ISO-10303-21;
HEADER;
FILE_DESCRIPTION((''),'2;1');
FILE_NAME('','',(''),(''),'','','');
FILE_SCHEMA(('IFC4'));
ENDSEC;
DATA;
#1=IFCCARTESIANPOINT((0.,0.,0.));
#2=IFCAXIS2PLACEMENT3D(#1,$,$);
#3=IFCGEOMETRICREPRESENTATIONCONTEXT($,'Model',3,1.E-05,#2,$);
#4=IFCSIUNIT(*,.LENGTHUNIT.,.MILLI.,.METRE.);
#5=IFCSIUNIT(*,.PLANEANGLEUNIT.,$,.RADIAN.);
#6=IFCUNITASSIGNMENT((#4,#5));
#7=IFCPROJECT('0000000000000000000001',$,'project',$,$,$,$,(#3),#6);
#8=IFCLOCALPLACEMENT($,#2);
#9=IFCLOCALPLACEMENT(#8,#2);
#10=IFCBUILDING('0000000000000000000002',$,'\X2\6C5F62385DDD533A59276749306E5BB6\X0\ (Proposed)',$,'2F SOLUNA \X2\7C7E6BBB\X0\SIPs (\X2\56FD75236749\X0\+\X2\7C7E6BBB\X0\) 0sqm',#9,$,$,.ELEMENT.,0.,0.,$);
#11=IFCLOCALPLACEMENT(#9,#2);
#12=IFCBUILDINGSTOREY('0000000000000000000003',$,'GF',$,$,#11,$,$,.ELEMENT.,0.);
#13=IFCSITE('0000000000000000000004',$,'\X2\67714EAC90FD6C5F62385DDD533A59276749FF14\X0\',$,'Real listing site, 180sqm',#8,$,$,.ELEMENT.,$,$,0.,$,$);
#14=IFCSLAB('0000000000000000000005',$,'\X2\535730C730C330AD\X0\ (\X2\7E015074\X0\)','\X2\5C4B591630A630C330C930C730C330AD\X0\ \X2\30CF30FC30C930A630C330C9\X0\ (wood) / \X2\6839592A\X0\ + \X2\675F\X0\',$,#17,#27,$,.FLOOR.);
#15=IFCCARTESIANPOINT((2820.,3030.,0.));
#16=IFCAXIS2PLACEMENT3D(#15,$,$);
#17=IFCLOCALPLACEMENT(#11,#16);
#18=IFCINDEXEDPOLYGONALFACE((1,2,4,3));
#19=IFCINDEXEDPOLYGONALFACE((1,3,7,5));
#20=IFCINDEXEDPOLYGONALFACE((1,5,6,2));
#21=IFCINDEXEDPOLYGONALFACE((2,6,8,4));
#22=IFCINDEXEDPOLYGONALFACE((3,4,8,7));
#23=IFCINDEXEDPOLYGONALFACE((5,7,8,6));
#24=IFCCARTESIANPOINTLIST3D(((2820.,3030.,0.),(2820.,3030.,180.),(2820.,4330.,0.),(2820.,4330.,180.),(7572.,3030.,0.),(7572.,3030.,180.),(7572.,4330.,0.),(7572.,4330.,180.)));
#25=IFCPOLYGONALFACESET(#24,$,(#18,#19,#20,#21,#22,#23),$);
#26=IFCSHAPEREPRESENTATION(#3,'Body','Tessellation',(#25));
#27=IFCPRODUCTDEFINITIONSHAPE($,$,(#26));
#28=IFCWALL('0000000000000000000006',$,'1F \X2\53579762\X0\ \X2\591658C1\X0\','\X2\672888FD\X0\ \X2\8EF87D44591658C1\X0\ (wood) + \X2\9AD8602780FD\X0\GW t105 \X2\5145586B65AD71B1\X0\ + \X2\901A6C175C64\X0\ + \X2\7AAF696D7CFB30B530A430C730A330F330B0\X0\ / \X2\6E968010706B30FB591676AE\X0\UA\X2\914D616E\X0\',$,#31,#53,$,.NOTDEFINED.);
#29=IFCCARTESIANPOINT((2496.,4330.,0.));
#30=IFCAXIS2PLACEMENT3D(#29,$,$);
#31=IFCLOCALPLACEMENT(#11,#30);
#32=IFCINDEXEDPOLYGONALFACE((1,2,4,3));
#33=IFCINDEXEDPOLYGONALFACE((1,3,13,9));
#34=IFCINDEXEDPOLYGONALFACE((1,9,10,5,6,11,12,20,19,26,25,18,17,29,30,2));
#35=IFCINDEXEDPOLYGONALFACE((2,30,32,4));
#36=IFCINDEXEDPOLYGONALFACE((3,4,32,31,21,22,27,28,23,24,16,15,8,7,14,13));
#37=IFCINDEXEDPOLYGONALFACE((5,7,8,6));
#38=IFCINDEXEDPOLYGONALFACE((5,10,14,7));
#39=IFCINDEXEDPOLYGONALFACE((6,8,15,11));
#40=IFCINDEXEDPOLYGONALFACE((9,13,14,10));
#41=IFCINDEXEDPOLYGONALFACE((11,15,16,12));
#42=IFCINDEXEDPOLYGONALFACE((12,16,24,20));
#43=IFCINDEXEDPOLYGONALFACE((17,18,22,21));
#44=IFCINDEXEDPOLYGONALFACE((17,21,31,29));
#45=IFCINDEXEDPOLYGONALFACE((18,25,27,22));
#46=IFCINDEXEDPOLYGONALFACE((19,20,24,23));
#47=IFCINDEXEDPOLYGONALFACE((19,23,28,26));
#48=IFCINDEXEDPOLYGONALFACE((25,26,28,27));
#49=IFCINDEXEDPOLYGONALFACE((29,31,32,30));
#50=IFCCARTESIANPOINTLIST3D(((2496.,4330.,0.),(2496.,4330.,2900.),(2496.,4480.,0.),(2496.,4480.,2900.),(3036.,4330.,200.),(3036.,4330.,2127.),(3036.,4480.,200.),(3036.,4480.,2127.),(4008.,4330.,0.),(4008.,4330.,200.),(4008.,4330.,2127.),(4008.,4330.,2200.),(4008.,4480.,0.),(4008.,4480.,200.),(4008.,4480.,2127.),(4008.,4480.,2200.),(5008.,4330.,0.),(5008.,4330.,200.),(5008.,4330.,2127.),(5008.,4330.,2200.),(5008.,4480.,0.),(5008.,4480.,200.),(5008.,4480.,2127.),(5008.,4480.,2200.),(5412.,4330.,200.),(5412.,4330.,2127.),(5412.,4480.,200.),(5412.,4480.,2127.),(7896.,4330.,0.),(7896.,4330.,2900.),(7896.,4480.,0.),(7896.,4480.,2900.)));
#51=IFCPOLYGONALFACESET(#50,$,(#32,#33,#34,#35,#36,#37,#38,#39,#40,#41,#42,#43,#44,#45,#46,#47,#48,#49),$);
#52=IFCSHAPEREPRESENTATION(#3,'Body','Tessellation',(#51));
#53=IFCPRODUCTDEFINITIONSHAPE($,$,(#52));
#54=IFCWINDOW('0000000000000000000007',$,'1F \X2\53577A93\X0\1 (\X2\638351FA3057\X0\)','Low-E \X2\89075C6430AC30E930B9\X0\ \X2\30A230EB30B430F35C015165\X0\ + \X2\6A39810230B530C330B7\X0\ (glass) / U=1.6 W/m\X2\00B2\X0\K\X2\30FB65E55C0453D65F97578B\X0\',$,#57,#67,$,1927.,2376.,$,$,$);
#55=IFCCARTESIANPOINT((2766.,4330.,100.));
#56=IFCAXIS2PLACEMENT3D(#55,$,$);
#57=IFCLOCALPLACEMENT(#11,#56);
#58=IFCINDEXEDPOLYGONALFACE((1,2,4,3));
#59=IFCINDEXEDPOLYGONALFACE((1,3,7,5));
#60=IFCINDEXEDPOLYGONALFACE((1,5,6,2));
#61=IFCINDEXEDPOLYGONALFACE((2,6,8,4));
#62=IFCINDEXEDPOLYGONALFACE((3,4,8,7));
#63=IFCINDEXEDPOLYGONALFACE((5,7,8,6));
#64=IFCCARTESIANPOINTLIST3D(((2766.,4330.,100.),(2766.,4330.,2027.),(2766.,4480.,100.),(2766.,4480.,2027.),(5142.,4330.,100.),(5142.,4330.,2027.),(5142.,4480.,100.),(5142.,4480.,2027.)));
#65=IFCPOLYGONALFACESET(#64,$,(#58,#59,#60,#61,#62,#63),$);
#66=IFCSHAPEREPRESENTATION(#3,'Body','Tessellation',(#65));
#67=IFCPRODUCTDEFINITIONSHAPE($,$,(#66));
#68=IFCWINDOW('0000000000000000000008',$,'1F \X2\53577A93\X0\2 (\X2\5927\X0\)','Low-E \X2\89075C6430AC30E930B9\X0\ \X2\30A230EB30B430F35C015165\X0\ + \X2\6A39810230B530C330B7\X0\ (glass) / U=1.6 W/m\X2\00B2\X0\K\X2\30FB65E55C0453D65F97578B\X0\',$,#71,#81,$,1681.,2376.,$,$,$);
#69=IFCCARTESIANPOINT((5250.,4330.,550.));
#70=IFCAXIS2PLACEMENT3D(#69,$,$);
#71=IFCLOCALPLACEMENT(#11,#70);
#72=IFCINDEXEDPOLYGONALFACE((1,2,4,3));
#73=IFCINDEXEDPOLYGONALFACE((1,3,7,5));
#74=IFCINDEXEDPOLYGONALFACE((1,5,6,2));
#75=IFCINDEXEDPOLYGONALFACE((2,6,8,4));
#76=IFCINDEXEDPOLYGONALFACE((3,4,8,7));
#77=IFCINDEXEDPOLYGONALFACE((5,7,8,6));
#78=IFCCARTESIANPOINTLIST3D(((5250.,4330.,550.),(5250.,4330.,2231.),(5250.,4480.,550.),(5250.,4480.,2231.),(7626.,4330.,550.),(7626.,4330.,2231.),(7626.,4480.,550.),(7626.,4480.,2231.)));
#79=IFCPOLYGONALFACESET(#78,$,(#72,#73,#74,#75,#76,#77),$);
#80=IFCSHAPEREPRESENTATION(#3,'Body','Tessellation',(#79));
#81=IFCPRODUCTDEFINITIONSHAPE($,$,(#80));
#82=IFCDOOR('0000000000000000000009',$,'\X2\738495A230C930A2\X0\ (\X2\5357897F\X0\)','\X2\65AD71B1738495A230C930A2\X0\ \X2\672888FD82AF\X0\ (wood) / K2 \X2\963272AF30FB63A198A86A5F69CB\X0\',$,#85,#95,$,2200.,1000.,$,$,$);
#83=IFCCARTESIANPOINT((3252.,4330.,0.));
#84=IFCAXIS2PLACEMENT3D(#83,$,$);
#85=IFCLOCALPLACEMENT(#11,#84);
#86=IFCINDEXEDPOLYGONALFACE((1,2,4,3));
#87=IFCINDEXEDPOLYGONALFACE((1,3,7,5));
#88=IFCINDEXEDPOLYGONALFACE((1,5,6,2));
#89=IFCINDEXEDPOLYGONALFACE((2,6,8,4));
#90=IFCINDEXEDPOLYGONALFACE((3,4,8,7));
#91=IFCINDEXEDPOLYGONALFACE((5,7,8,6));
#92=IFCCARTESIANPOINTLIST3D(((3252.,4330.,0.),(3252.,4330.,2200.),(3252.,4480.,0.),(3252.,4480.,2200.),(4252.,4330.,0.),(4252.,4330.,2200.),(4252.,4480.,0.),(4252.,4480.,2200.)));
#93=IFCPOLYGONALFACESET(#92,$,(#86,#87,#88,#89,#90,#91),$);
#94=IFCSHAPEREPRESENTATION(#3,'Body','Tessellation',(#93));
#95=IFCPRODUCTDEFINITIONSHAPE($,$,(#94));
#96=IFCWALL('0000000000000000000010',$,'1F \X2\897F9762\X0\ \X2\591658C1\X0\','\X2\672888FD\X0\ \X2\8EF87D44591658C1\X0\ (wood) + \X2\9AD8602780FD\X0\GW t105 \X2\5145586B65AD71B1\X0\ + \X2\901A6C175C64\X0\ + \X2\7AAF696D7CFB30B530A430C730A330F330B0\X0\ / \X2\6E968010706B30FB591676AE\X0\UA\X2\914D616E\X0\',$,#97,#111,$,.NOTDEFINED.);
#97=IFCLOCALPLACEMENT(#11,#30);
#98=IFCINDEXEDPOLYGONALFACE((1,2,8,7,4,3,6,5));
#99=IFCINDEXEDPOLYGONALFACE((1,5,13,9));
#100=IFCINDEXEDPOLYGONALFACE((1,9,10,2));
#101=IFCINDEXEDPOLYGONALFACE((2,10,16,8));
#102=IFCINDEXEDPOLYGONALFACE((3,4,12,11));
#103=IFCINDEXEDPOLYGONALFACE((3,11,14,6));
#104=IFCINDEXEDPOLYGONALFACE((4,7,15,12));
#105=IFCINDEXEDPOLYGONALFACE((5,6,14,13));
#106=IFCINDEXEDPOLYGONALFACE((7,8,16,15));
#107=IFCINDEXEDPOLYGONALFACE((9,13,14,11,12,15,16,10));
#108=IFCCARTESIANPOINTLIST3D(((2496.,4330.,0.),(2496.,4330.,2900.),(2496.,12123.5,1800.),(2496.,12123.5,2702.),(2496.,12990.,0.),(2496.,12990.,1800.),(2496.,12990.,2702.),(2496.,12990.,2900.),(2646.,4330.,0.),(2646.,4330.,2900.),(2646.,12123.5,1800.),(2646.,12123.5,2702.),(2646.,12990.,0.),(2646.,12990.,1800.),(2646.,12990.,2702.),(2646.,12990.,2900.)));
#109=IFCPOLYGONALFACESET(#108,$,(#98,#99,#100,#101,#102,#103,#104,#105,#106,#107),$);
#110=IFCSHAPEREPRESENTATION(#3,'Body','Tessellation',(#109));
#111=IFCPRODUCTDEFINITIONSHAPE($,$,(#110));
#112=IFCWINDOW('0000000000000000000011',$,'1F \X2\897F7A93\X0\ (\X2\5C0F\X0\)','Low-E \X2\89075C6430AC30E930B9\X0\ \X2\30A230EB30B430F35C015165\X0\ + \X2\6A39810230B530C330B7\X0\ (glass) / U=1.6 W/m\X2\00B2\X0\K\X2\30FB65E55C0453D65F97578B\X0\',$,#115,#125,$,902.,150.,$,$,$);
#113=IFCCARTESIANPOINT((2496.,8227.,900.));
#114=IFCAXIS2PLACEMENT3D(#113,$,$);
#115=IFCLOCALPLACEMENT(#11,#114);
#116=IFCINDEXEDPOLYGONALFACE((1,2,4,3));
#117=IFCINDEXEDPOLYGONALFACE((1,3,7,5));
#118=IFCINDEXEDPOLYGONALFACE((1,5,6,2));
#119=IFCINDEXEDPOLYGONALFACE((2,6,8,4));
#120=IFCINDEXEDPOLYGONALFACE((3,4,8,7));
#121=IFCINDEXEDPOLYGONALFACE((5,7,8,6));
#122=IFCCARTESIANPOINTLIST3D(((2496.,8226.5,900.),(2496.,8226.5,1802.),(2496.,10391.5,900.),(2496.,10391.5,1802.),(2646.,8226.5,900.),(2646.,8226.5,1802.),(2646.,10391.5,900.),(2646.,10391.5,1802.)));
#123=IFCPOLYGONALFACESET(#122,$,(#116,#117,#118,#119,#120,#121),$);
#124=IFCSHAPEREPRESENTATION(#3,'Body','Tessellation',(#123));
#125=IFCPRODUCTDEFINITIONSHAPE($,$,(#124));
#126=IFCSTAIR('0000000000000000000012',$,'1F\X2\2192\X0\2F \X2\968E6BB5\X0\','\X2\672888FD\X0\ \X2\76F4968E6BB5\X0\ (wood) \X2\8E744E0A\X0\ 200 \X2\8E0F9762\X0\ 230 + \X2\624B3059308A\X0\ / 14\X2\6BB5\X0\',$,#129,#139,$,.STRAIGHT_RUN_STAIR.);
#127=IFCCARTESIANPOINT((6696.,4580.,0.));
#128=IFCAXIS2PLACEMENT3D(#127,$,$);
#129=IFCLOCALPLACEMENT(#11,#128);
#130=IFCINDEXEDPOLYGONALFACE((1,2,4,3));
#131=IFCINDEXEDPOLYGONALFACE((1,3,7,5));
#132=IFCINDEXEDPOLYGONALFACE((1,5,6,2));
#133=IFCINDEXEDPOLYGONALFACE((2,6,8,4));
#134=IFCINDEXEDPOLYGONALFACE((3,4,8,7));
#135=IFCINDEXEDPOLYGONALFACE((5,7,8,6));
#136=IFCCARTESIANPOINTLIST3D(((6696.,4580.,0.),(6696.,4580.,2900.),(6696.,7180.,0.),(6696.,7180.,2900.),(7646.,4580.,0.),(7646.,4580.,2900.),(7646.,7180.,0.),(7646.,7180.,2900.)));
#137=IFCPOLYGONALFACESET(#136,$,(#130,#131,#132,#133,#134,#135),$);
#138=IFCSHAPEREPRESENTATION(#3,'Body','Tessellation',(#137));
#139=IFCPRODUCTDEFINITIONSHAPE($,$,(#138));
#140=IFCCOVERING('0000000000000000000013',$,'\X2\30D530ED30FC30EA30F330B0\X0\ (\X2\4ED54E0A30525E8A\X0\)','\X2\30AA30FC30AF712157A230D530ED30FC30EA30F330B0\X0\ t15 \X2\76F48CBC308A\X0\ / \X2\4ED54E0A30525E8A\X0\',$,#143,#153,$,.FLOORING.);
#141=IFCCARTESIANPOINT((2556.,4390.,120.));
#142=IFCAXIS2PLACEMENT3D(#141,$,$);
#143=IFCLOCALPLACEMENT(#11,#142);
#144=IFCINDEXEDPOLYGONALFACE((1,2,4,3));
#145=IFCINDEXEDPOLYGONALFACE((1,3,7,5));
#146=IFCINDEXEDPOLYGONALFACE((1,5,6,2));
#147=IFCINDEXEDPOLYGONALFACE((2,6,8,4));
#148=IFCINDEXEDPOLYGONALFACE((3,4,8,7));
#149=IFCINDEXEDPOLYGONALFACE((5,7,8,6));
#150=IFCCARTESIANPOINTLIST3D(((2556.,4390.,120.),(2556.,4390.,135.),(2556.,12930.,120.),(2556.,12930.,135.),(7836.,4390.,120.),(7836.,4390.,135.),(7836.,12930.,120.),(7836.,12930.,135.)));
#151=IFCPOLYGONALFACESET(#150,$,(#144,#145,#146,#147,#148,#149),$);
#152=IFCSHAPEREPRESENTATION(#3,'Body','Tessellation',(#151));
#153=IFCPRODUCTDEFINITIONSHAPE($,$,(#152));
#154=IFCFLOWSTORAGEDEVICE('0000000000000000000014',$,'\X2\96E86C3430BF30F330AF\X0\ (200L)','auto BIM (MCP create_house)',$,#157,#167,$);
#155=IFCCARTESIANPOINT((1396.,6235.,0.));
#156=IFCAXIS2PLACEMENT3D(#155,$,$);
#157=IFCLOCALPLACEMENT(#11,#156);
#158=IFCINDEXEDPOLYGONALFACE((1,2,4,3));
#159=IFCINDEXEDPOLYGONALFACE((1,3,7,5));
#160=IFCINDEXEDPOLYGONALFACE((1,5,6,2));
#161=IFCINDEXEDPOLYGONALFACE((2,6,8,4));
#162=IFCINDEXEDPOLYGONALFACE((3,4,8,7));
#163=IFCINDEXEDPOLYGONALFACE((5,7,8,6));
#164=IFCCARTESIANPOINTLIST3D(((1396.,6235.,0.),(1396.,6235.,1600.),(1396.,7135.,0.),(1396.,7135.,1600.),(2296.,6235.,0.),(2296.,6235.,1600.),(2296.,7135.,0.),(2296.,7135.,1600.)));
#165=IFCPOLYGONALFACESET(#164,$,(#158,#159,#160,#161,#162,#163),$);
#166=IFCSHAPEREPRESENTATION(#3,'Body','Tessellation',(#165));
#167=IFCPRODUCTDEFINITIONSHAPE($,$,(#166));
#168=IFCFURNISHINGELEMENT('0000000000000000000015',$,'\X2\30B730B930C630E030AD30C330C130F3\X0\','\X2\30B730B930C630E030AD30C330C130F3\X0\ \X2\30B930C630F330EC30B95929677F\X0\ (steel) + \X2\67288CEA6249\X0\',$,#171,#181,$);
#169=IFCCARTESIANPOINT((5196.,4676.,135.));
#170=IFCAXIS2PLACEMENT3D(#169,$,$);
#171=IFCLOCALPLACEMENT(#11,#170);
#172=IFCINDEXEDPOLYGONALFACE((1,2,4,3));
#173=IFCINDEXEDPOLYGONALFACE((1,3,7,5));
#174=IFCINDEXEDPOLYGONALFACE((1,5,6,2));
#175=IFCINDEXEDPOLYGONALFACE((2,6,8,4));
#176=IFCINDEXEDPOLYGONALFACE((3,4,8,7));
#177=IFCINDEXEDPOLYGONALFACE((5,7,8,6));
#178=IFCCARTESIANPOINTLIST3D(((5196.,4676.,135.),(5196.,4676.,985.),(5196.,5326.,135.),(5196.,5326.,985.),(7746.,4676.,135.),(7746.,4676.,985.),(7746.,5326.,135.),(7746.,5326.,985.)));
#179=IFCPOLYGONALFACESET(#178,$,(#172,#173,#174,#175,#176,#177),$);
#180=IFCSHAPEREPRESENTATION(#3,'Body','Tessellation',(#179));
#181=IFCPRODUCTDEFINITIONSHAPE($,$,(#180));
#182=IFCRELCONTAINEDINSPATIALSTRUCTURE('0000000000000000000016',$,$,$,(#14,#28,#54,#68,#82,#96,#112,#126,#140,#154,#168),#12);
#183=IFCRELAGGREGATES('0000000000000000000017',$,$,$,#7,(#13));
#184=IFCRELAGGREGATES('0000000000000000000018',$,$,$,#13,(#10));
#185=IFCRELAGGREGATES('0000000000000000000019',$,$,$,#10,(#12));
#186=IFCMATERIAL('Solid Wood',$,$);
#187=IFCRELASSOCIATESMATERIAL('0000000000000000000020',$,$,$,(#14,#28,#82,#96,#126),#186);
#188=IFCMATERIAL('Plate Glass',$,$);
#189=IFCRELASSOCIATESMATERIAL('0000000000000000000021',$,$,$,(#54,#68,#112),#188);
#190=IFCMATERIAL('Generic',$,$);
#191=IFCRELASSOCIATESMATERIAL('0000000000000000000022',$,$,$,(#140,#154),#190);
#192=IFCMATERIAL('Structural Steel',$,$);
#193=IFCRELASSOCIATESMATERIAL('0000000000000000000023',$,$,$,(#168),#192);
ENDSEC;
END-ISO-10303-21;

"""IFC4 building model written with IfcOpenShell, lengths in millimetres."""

from ifc_helpers import new_model, si_unit, frame, frame_2d, origin, place, context, project, spatial, rectangle, extrude, material, element, fill, save


model = new_model("IFC4")

# Units and contexts
model_context = context("Model", 3, precision=1e-05, world=origin())
ifc_project = project(units=[si_unit("LENGTHUNIT", "METRE", prefix="MILLI"), si_unit("PLANEANGLEUNIT", "RADIAN")], contexts=[model_context])

# Site, building, storey
site_placement = place(None, origin())
site = spatial("IfcSite", under=ifc_project, at=site_placement, Name="東京都江戸川区大杉４", ObjectType="Real listing site, 180sqm", CompositionType="ELEMENT", RefElevation=0.0)
building_placement = place(site_placement, origin())
building = spatial("IfcBuilding", under=site, at=building_placement, Name="江戸川区大杉の家 (Proposed)", ObjectType="2F SOLUNA 籾殻SIPs (国産杉+籾殻) 0sqm", CompositionType="ELEMENT", ElevationOfRefHeight=0.0, ElevationOfTerrain=0.0)
storey_placement = place(building_placement, origin())
storey = spatial("IfcBuildingStorey", under=building, at=storey_placement, Name="GF", CompositionType="ELEMENT", Elevation=0.0)

# Slab
ifc_material_1 = material(Name="Solid Wood")
slab_1_placement = place(storey_placement, frame((2820.0, 3030.0, 0.0)))
element("IfcSlab", 1, at=slab_1_placement, inside=storey, material=ifc_material_1, Name="南デッキ (縁側)", Description="屋外ウッドデッキ ハードウッド (wood) / 根太 + 束", PredefinedType="FLOOR", context=model_context, shape_type="SweptSolid", body=[
    extrude(rectangle(XDim=4752.0, YDim=1300.0, at=frame_2d((2376.0, 650.0))), frame((2820.0, 3030.0, 0.0)), (0.0, 0.0, 1.0), 180.0),
])

# Wall, openings, windows, door
wall_1_placement = place(storey_placement, frame((2496.0, 4330.0, 0.0)))
wall_1 = element("IfcWall", 2, at=wall_1_placement, inside=storey, material=ifc_material_1, Name="1F 南面 外壁", Description="木製 軸組外壁 (wood) + 高性能GW t105 充填断熱 + 通気層 + 窯業系サイディング / 準耐火・外皮UA配慮", PredefinedType="NOTDEFINED", context=model_context, shape_type="SweptSolid", body=[
    extrude(rectangle(XDim=5400.0, YDim=150.0, at=frame_2d((2700.0, 75.0))), frame((2496.0, 4330.0, 0.0)), (0.0, 0.0, 1.0), 2900.0),
])
opening_1_placement = place(storey_placement, frame((2766.0, 4330.0, 100.0)))
opening_1 = element("IfcOpeningElement", 3, at=opening_1_placement, cuts=wall_1, PredefinedType="NOTDEFINED", context=model_context, shape_type="SweptSolid", body=[
    extrude(rectangle(XDim=2376.0, YDim=150.0, at=frame_2d((1188.0, 75.0))), frame((2766.0, 4330.0, 100.0)), (0.0, 0.0, 1.0), 1927.0),
])
opening_2_placement = place(storey_placement, frame((5250.0, 4330.0, 550.0)))
opening_2 = element("IfcOpeningElement", 4, at=opening_2_placement, cuts=wall_1, PredefinedType="NOTDEFINED", context=model_context, shape_type="SweptSolid", body=[
    extrude(rectangle(XDim=2376.0, YDim=150.0, at=frame_2d((1188.0, 75.0))), frame((5250.0, 4330.0, 550.0)), (0.0, 0.0, 1.0), 1681.0),
])
opening_3_placement = place(storey_placement, frame((3252.0, 4330.0, 0.0)))
opening_3 = element("IfcOpeningElement", 5, at=opening_3_placement, cuts=wall_1, PredefinedType="NOTDEFINED", context=model_context, shape_type="SweptSolid", body=[
    extrude(rectangle(XDim=1000.0, YDim=150.0, at=frame_2d((500.0, 75.0))), frame((3252.0, 4330.0, 0.0)), (0.0, 0.0, 1.0), 2200.0),
])
ifc_material_2 = material(Name="Plate Glass")
window_1_placement = place(storey_placement, frame((2766.0, 4330.0, 100.0)))
window_1 = element("IfcWindow", 6, at=window_1_placement, inside=storey, material=ifc_material_2, Name="1F 南窓1 (掃出し)", Description="Low-E 複層ガラス アルゴン封入 + 樹脂サッシ (glass) / U=1.6 W/m²K・日射取得型", OverallHeight=1927.0, OverallWidth=2376.0, context=model_context, shape_type="SweptSolid", body=[
    extrude(rectangle(XDim=2376.0, YDim=150.0, at=frame_2d((1188.0, 75.0))), frame((2766.0, 4330.0, 100.0)), (0.0, 0.0, 1.0), 1927.0),
])
fill(opening_1, window_1)
window_2_placement = place(storey_placement, frame((5250.0, 4330.0, 550.0)))
window_2 = element("IfcWindow", 7, at=window_2_placement, inside=storey, material=ifc_material_2, Name="1F 南窓2 (大)", Description="Low-E 複層ガラス アルゴン封入 + 樹脂サッシ (glass) / U=1.6 W/m²K・日射取得型", OverallHeight=1681.0, OverallWidth=2376.0, context=model_context, shape_type="SweptSolid", body=[
    extrude(rectangle(XDim=2376.0, YDim=150.0, at=frame_2d((1188.0, 75.0))), frame((5250.0, 4330.0, 550.0)), (0.0, 0.0, 1.0), 1681.0),
])
fill(opening_2, window_2)
door_placement = place(storey_placement, frame((3252.0, 4330.0, 0.0)))
door = element("IfcDoor", 8, at=door_placement, inside=storey, material=ifc_material_1, Name="玄関ドア (南西)", Description="断熱玄関ドア 木製芯 (wood) / K2 防犯・採風機構", OverallHeight=2200.0, OverallWidth=1000.0, context=model_context, shape_type="SweptSolid", body=[
    extrude(rectangle(XDim=1000.0, YDim=150.0, at=frame_2d((500.0, 75.0))), frame((3252.0, 4330.0, 0.0)), (0.0, 0.0, 1.0), 2200.0),
])
fill(opening_3, door)

# Wall, opening, window
wall_2_placement = place(storey_placement, frame((2496.0, 4330.0, 0.0)))
wall_2 = element("IfcWall", 9, at=wall_2_placement, inside=storey, material=ifc_material_1, Name="1F 西面 外壁", Description="木製 軸組外壁 (wood) + 高性能GW t105 充填断熱 + 通気層 + 窯業系サイディング / 準耐火・外皮UA配慮", PredefinedType="NOTDEFINED", context=model_context, shape_type="SweptSolid", body=[
    extrude(rectangle(XDim=150.0, YDim=8660.0, at=frame_2d((75.0, 4330.0))), frame((2496.0, 4330.0, 0.0)), (0.0, 0.0, 1.0), 2900.0),
])
opening_4_placement = place(storey_placement, frame((2496.0, 8227.0, 900.0)))
opening_4 = element("IfcOpeningElement", 10, at=opening_4_placement, cuts=wall_2, PredefinedType="NOTDEFINED", context=model_context, shape_type="SweptSolid", body=[
    extrude(rectangle(XDim=150.0, YDim=2165.0, at=frame_2d((75.0, 1082.0))), frame((2496.0, 8227.0, 900.0)), (0.0, 0.0, 1.0), 902.0),
])
window_3_placement = place(storey_placement, frame((2496.0, 8227.0, 900.0)))
window_3 = element("IfcWindow", 11, at=window_3_placement, inside=storey, material=ifc_material_2, Name="1F 西窓 (小)", Description="Low-E 複層ガラス アルゴン封入 + 樹脂サッシ (glass) / U=1.6 W/m²K・日射取得型", OverallHeight=902.0, OverallWidth=150.0, context=model_context, shape_type="SweptSolid", body=[
    extrude(rectangle(XDim=150.0, YDim=2165.0, at=frame_2d((75.0, 1082.0))), frame((2496.0, 8227.0, 900.0)), (0.0, 0.0, 1.0), 902.0),
])
fill(opening_4, window_3)

# Stair
stair_placement = place(storey_placement, frame((6696.0, 4580.0, 0.0)))
element("IfcStair", 12, at=stair_placement, inside=storey, material=ifc_material_1, Name="1F→2F 階段", Description="木製 直階段 (wood) 蹴上 200 踏面 230 + 手すり / 14段", PredefinedType="STRAIGHT_RUN_STAIR", context=model_context, shape_type="SweptSolid", body=[
    extrude(rectangle(XDim=950.0, YDim=2600.0, at=frame_2d((475.0, 1300.0))), frame((6696.0, 4580.0, 0.0)), (0.0, 0.0, 1.0), 2900.0),
])

# Covering
ifc_material_3 = material(Name="Generic")
covering_placement = place(storey_placement, frame((2556.0, 4390.0, 120.0)))
element("IfcCovering", 13, at=covering_placement, inside=storey, material=ifc_material_3, Name="フローリング (仕上げ床)", Description="オーク無垢フローリング t15 直貼り / 仕上げ床", PredefinedType="FLOORING", context=model_context, shape_type="SweptSolid", body=[
    extrude(rectangle(XDim=5280.0, YDim=8540.0, at=frame_2d((2640.0, 4270.0))), frame((2556.0, 4390.0, 120.0)), (0.0, 0.0, 1.0), 15.0),
])

# Flow storage device
flow_storage_device_placement = place(storey_placement, frame((1396.0, 6235.0, 0.0)))
element("IfcFlowStorageDevice", 14, at=flow_storage_device_placement, inside=storey, material=ifc_material_3, Name="雨水タンク (200L)", Description="auto BIM (MCP create_house)", context=model_context, shape_type="SweptSolid", body=[
    extrude(rectangle(XDim=900.0, YDim=900.0, at=frame_2d((450.0, 450.0))), frame((1396.0, 6235.0, 0.0)), (0.0, 0.0, 1.0), 1600.0),
])

# Furnishing element
ifc_material_4 = material(Name="Structural Steel")
furnishing_placement = place(storey_placement, frame((5196.0, 4676.0, 135.0)))
element("IfcFurnishingElement", 15, at=furnishing_placement, inside=storey, material=ifc_material_4, Name="システムキッチン", Description="システムキッチン ステンレス天板 (steel) + 木質扉", context=model_context, shape_type="SweptSolid", body=[
    extrude(rectangle(XDim=2550.0, YDim=650.0, at=frame_2d((1275.0, 325.0))), frame((5196.0, 4676.0, 135.0)), (0.0, 0.0, 1.0), 850.0),
])

save(model, "model.ifc")
